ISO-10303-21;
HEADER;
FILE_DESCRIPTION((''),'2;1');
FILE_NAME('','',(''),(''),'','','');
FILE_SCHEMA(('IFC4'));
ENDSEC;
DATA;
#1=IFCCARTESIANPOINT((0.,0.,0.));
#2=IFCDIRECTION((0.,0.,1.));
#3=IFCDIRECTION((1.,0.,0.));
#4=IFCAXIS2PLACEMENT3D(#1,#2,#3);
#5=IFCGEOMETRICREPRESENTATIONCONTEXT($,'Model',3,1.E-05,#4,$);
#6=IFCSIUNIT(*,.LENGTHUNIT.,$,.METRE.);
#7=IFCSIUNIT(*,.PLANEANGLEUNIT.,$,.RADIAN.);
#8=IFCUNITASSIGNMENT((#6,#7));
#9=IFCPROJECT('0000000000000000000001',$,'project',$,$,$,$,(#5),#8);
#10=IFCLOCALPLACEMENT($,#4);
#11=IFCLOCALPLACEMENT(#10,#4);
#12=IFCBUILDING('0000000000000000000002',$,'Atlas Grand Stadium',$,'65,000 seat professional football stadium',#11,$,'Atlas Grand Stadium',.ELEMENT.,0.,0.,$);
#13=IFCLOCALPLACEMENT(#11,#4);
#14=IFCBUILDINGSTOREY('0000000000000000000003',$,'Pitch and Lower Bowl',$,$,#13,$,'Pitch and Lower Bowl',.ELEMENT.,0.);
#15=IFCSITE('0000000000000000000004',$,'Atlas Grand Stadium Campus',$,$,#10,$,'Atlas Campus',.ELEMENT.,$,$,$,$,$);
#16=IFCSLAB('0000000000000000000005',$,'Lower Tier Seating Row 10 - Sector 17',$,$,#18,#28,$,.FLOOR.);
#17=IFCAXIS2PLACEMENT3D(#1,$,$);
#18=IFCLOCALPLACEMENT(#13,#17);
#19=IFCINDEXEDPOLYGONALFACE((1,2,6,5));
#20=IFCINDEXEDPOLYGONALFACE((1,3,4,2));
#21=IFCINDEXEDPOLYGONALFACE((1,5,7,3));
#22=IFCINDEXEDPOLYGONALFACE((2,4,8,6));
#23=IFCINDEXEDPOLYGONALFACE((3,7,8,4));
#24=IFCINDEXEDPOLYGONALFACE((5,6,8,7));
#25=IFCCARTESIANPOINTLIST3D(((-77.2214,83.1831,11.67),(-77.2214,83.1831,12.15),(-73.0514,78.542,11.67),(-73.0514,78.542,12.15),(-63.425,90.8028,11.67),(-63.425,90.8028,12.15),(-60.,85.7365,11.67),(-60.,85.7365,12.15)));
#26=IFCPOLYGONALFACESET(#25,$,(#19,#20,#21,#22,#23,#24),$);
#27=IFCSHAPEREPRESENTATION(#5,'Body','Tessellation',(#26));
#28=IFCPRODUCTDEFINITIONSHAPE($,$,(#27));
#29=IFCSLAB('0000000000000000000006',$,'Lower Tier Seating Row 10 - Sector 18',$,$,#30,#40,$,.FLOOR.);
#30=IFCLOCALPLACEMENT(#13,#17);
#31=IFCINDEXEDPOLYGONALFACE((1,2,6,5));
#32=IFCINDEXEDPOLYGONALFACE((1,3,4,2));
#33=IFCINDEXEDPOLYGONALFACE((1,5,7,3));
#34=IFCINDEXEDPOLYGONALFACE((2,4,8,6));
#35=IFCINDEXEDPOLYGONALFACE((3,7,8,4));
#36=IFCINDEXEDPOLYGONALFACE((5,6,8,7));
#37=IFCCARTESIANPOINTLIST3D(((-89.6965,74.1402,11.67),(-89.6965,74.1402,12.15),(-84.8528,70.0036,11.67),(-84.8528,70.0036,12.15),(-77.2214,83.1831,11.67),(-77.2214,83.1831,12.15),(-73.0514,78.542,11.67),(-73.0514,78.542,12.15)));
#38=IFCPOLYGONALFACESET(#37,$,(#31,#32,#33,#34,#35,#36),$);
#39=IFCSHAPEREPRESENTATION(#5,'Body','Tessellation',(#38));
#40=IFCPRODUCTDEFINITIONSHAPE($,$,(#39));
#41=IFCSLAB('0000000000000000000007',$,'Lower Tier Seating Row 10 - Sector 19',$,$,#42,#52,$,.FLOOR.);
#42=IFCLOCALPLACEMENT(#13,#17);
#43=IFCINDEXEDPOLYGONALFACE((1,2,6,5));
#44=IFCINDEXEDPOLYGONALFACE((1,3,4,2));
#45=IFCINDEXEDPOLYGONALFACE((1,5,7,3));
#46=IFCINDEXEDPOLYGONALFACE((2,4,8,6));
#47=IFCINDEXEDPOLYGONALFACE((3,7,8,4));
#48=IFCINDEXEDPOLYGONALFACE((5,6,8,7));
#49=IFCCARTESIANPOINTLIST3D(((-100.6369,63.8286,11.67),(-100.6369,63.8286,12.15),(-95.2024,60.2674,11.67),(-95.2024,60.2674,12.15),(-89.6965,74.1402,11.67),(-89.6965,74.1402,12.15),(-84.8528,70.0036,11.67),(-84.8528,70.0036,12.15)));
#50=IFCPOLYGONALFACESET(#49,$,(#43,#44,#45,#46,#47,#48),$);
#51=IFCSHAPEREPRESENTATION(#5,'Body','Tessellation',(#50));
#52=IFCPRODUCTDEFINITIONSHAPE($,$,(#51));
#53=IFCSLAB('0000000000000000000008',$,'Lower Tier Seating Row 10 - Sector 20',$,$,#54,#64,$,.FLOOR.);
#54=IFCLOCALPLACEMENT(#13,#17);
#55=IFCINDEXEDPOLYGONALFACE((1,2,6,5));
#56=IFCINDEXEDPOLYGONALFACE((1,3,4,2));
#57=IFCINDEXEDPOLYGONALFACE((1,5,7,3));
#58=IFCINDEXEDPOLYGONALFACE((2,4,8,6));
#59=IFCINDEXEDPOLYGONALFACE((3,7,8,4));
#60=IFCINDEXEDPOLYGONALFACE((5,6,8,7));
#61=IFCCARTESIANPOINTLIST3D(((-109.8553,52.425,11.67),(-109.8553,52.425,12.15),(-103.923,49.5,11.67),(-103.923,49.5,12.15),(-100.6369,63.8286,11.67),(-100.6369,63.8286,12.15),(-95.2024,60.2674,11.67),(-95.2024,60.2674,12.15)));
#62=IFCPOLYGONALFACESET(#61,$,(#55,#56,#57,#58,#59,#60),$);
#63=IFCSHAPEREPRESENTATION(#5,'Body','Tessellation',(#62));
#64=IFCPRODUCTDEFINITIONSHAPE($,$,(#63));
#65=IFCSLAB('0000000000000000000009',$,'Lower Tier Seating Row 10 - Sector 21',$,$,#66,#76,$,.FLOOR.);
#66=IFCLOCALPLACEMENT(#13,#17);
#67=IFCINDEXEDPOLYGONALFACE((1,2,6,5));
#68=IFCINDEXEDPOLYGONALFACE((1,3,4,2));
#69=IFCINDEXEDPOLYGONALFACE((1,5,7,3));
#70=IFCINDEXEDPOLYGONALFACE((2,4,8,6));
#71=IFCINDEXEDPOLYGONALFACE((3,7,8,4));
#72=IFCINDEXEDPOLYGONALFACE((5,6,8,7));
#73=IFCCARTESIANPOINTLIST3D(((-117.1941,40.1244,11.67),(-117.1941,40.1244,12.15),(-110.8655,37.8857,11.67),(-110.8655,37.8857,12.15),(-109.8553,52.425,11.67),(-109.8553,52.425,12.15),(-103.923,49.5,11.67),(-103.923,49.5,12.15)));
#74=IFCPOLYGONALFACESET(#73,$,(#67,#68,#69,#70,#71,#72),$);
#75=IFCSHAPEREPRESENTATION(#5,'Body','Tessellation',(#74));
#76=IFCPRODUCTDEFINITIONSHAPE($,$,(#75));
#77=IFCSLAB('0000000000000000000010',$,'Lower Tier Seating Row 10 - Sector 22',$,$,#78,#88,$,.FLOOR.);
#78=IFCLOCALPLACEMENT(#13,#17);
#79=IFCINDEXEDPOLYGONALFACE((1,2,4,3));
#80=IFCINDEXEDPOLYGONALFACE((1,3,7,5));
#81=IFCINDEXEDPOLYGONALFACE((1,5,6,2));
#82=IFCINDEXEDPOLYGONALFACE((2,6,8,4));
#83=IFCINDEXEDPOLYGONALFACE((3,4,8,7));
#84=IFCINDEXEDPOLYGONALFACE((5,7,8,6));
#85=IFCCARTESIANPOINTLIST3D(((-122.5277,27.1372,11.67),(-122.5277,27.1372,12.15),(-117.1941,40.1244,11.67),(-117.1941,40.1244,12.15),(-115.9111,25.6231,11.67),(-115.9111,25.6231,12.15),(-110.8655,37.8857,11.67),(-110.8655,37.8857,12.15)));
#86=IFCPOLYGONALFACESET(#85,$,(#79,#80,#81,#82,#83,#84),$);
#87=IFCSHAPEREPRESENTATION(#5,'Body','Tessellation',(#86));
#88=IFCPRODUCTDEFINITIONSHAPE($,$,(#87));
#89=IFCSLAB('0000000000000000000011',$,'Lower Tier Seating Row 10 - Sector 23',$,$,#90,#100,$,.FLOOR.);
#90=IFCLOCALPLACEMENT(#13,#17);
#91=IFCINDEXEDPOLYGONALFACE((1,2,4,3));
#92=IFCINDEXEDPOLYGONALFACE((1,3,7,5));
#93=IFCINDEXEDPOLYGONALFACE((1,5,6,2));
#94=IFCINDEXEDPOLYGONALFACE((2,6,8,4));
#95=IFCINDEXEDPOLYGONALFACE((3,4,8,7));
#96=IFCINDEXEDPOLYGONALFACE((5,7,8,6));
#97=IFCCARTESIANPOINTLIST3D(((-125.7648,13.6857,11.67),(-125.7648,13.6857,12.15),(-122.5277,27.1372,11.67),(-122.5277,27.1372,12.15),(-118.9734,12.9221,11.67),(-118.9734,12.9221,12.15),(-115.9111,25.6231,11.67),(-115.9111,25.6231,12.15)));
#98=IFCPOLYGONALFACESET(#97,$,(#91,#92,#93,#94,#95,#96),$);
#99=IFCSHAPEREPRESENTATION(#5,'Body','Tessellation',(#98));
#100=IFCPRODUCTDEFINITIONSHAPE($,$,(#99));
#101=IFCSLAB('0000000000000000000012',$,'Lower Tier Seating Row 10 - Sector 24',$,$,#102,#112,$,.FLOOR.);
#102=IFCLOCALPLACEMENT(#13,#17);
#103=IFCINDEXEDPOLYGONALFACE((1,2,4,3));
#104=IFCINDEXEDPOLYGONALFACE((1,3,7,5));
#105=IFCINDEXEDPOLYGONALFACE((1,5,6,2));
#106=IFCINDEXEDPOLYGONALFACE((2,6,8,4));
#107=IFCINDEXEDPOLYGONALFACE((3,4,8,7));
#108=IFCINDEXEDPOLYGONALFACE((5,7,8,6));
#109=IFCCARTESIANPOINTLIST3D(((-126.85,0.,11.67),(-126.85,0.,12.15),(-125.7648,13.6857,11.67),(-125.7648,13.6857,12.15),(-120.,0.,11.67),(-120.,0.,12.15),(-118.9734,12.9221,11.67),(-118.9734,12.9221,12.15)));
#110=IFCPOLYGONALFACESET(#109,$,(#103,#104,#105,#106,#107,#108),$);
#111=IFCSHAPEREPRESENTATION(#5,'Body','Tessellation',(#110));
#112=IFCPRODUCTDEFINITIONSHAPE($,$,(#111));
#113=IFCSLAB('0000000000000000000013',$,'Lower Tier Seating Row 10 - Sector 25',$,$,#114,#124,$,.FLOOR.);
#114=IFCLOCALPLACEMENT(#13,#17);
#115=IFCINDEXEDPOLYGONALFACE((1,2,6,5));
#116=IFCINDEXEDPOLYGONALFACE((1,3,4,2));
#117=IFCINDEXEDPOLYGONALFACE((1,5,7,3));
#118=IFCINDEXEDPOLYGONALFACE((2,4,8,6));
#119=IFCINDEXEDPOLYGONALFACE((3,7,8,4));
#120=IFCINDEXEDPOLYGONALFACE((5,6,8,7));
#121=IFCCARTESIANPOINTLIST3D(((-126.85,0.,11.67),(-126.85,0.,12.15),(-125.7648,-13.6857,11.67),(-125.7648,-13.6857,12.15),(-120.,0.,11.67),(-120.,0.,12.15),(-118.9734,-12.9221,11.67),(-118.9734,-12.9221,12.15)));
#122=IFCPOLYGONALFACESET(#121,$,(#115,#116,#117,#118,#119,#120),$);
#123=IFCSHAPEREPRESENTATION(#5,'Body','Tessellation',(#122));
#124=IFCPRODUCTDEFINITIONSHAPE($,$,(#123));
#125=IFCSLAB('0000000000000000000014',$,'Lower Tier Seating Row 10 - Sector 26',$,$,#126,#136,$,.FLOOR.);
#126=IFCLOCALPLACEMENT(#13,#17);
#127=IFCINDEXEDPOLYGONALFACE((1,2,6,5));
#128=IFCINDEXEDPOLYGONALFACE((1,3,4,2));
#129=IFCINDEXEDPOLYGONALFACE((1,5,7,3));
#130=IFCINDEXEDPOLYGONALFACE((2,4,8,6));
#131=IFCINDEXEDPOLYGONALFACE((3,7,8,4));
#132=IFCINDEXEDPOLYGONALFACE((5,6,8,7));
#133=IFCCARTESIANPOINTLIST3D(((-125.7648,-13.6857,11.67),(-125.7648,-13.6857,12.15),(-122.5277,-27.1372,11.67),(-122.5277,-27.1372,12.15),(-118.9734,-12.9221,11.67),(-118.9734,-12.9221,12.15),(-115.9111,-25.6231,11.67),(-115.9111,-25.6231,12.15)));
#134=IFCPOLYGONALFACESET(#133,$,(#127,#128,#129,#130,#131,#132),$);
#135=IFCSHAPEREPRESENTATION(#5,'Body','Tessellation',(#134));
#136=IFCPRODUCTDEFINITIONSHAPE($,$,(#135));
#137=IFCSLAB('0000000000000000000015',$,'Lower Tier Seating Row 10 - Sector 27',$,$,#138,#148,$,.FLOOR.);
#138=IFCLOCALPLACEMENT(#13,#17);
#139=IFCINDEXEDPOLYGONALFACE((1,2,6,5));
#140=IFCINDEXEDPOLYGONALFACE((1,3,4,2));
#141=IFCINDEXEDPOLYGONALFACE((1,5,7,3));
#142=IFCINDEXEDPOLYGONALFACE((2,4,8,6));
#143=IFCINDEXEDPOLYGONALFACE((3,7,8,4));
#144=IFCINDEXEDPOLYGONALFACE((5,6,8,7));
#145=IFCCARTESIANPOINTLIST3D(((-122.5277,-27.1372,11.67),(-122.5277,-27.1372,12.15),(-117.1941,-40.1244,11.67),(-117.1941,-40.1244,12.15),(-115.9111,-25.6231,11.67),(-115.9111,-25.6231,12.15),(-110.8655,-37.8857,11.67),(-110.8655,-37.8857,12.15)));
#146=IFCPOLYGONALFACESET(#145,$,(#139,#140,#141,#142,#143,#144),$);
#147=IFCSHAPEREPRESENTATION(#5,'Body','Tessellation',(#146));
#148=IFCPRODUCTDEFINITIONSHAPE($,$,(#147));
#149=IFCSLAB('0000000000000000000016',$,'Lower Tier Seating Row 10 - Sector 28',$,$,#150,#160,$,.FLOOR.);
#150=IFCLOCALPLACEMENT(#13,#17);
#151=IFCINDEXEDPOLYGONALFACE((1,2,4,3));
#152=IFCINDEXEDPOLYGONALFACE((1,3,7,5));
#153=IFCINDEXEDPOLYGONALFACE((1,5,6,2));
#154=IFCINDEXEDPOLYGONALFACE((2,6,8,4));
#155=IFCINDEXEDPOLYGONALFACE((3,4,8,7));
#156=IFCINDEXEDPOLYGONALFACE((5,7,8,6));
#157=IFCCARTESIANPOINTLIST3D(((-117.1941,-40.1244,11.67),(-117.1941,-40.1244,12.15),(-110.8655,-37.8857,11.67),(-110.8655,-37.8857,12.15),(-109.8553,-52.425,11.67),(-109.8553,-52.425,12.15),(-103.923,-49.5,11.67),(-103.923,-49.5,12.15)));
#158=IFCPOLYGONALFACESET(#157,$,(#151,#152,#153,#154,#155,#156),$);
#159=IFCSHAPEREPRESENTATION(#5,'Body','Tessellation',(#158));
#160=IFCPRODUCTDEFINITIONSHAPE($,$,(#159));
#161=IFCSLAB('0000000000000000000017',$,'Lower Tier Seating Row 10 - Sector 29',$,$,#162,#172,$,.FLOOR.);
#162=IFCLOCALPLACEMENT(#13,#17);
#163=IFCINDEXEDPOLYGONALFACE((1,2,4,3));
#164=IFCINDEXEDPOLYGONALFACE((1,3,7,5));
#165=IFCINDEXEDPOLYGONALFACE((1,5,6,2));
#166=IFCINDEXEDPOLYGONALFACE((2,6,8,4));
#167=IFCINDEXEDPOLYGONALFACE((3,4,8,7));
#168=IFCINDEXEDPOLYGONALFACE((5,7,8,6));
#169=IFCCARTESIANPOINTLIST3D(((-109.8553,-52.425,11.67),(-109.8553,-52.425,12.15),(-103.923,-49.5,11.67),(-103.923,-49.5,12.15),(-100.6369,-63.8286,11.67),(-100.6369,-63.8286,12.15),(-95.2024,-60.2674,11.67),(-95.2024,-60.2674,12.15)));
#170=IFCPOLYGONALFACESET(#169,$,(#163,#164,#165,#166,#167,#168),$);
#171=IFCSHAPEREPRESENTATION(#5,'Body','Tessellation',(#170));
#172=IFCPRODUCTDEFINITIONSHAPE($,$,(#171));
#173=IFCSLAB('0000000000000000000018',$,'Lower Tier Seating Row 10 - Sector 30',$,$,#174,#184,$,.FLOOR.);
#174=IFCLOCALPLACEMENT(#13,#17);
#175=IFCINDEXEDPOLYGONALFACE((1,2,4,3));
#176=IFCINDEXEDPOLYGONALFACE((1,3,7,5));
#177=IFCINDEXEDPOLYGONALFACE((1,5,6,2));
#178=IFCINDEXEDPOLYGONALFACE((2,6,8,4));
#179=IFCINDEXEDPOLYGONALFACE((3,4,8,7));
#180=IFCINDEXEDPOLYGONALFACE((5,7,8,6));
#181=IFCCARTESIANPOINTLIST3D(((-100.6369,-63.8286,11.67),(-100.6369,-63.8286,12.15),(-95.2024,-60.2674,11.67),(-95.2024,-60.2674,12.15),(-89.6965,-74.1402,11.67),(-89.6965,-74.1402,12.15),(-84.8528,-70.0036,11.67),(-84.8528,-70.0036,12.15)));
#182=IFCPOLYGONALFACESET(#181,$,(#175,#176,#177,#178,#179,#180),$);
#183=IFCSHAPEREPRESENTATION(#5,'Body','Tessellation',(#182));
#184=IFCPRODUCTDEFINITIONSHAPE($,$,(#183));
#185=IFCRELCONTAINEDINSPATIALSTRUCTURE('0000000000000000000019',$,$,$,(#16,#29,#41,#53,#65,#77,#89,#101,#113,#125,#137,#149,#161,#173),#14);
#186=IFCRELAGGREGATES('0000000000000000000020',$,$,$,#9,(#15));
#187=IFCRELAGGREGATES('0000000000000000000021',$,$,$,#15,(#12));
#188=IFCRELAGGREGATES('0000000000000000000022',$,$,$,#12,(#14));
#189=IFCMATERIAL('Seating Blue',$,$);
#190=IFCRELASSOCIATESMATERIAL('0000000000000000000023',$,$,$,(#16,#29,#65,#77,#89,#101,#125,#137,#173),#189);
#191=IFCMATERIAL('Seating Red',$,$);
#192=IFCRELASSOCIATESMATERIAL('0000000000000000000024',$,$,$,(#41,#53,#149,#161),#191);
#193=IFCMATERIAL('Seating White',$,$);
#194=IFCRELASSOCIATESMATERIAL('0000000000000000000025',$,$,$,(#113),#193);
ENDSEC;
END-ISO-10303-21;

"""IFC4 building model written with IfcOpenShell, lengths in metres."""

from ifc_helpers import new_model, si_unit, frame, origin_with_axes, place, context, project, spatial, polyline, outline, extrude, material, element, save


model = new_model("IFC4")

# Units and contexts
model_context = context("Model", 3, precision=1e-05, world=origin_with_axes())
ifc_project = project(units=[si_unit("LENGTHUNIT", "METRE"), si_unit("PLANEANGLEUNIT", "RADIAN")], contexts=[model_context])

# Site, building, storey
site_placement = place(None, origin_with_axes())
site = spatial("IfcSite", under=ifc_project, at=site_placement, Name="Atlas Grand Stadium Campus", LongName="Atlas Campus", CompositionType="ELEMENT")
building_placement = place(site_placement, origin_with_axes())
building = spatial("IfcBuilding", under=site, at=building_placement, Name="Atlas Grand Stadium", ObjectType="65,000 seat professional football stadium", LongName="Atlas Grand Stadium", CompositionType="ELEMENT", ElevationOfRefHeight=0.0, ElevationOfTerrain=0.0)
storey_placement = place(building_placement, origin_with_axes())
storey = spatial("IfcBuildingStorey", under=building, at=storey_placement, Name="Pitch and Lower Bowl", LongName="Pitch and Lower Bowl", CompositionType="ELEMENT", Elevation=0.0)

# Slabs
ifc_material_1 = material(Name="Seating Blue")
slab_1_placement = place(storey_placement, frame((0.0, 0.0, 11.67), z_axis=(0.0, 0.0, 1.0), x_axis=(1.0, 0.0, 0.0)))
element("IfcSlab", 1, at=slab_1_placement, inside=storey, material=ifc_material_1, Name="Lower Tier Seating Row 10 - Sector 17", PredefinedType="FLOOR", context=model_context, shape_type="SweptSolid", body=[
    extrude(outline(polyline([(-63.425, 90.8028), (-77.2214, 83.1831), (-73.0514, 78.542), (-60.0, 85.7365), (-63.425, 90.8028)])), origin_with_axes(), (0.0, 0.0, 1.0), 0.48),
])
slab_2_placement = place(storey_placement, frame((0.0, 0.0, 11.67), z_axis=(0.0, 0.0, 1.0), x_axis=(1.0, 0.0, 0.0)))
element("IfcSlab", 2, at=slab_2_placement, inside=storey, material=ifc_material_1, Name="Lower Tier Seating Row 10 - Sector 18", PredefinedType="FLOOR", context=model_context, shape_type="SweptSolid", body=[
    extrude(outline(polyline([(-77.2214, 83.1831), (-89.6965, 74.1402), (-84.8528, 70.0036), (-73.0514, 78.542), (-77.2214, 83.1831)])), origin_with_axes(), (0.0, 0.0, 1.0), 0.48),
])
ifc_material_2 = material(Name="Seating Red")
slab_3_placement = place(storey_placement, frame((0.0, 0.0, 11.67), z_axis=(0.0, 0.0, 1.0), x_axis=(1.0, 0.0, 0.0)))
element("IfcSlab", 3, at=slab_3_placement, inside=storey, material=ifc_material_2, Name="Lower Tier Seating Row 10 - Sector 19", PredefinedType="FLOOR", context=model_context, shape_type="SweptSolid", body=[
    extrude(outline(polyline([(-89.6965, 74.1402), (-100.6369, 63.8286), (-95.2024, 60.2674), (-84.8528, 70.0036), (-89.6965, 74.1402)])), origin_with_axes(), (0.0, 0.0, 1.0), 0.48),
])
slab_4_placement = place(storey_placement, frame((0.0, 0.0, 11.67), z_axis=(0.0, 0.0, 1.0), x_axis=(1.0, 0.0, 0.0)))
element("IfcSlab", 4, at=slab_4_placement, inside=storey, material=ifc_material_2, Name="Lower Tier Seating Row 10 - Sector 20", PredefinedType="FLOOR", context=model_context, shape_type="SweptSolid", body=[
    extrude(outline(polyline([(-100.6369, 63.8286), (-109.8553, 52.425), (-103.9231, 49.5), (-95.2024, 60.2674), (-100.6369, 63.8286)])), origin_with_axes(), (0.0, 0.0, 1.0), 0.48),
])
slab_5_placement = place(storey_placement, frame((0.0, 0.0, 11.67), z_axis=(0.0, 0.0, 1.0), x_axis=(1.0, 0.0, 0.0)))
element("IfcSlab", 5, at=slab_5_placement, inside=storey, material=ifc_material_1, Name="Lower Tier Seating Row 10 - Sector 21", PredefinedType="FLOOR", context=model_context, shape_type="SweptSolid", body=[
    extrude(outline(polyline([(-109.8553, 52.425), (-117.1941, 40.1244), (-110.8655, 37.8857), (-103.9231, 49.5), (-109.8553, 52.425)])), origin_with_axes(), (0.0, 0.0, 1.0), 0.48),
])
slab_6_placement = place(storey_placement, frame((0.0, 0.0, 11.67), z_axis=(0.0, 0.0, 1.0), x_axis=(1.0, 0.0, 0.0)))
element("IfcSlab", 6, at=slab_6_placement, inside=storey, material=ifc_material_1, Name="Lower Tier Seating Row 10 - Sector 22", PredefinedType="FLOOR", context=model_context, shape_type="SweptSolid", body=[
    extrude(outline(polyline([(-117.1941, 40.1244), (-122.5277, 27.1372), (-115.9111, 25.6231), (-110.8655, 37.8857), (-117.1941, 40.1244)])), origin_with_axes(), (0.0, 0.0, 1.0), 0.48),
])
slab_7_placement = place(storey_placement, frame((0.0, 0.0, 11.67), z_axis=(0.0, 0.0, 1.0), x_axis=(1.0, 0.0, 0.0)))
element("IfcSlab", 7, at=slab_7_placement, inside=storey, material=ifc_material_1, Name="Lower Tier Seating Row 10 - Sector 23", PredefinedType="FLOOR", context=model_context, shape_type="SweptSolid", body=[
    extrude(outline(polyline([(-122.5277, 27.1372), (-125.7648, 13.6857), (-118.9734, 12.9221), (-115.9111, 25.6231), (-122.5277, 27.1372)])), origin_with_axes(), (0.0, 0.0, 1.0), 0.48),
])
slab_8_placement = place(storey_placement, frame((0.0, 0.0, 11.67), z_axis=(0.0, 0.0, 1.0), x_axis=(1.0, 0.0, 0.0)))
element("IfcSlab", 8, at=slab_8_placement, inside=storey, material=ifc_material_1, Name="Lower Tier Seating Row 10 - Sector 24", PredefinedType="FLOOR", context=model_context, shape_type="SweptSolid", body=[
    extrude(outline(polyline([(-125.7648, 13.6857), (-126.85, 0.0), (-120.0, 0.0), (-118.9734, 12.9221), (-125.7648, 13.6857)])), origin_with_axes(), (0.0, 0.0, 1.0), 0.48),
])
ifc_material_3 = material(Name="Seating White")
slab_9_placement = place(storey_placement, frame((0.0, 0.0, 11.67), z_axis=(0.0, 0.0, 1.0), x_axis=(1.0, 0.0, 0.0)))
element("IfcSlab", 9, at=slab_9_placement, inside=storey, material=ifc_material_3, Name="Lower Tier Seating Row 10 - Sector 25", PredefinedType="FLOOR", context=model_context, shape_type="SweptSolid", body=[
    extrude(outline(polyline([(-126.85, 0.0), (-125.7648, -13.6857), (-118.9734, -12.9221), (-120.0, 0.0), (-126.85, 0.0)])), origin_with_axes(), (0.0, 0.0, 1.0), 0.48),
])
slab_10_placement = place(storey_placement, frame((0.0, 0.0, 11.67), z_axis=(0.0, 0.0, 1.0), x_axis=(1.0, 0.0, 0.0)))
element("IfcSlab", 10, at=slab_10_placement, inside=storey, material=ifc_material_1, Name="Lower Tier Seating Row 10 - Sector 26", PredefinedType="FLOOR", context=model_context, shape_type="SweptSolid", body=[
    extrude(outline(polyline([(-125.7648, -13.6857), (-122.5277, -27.1372), (-115.9111, -25.6231), (-118.9734, -12.9221), (-125.7648, -13.6857)])), origin_with_axes(), (0.0, 0.0, 1.0), 0.48),
])
slab_11_placement = place(storey_placement, frame((0.0, 0.0, 11.67), z_axis=(0.0, 0.0, 1.0), x_axis=(1.0, 0.0, 0.0)))
element("IfcSlab", 11, at=slab_11_placement, inside=storey, material=ifc_material_1, Name="Lower Tier Seating Row 10 - Sector 27", PredefinedType="FLOOR", context=model_context, shape_type="SweptSolid", body=[
    extrude(outline(polyline([(-122.5277, -27.1372), (-117.1941, -40.1244), (-110.8655, -37.8857), (-115.9111, -25.6231), (-122.5277, -27.1372)])), origin_with_axes(), (0.0, 0.0, 1.0), 0.48),
])
slab_12_placement = place(storey_placement, frame((0.0, 0.0, 11.67), z_axis=(0.0, 0.0, 1.0), x_axis=(1.0, 0.0, 0.0)))
element("IfcSlab", 12, at=slab_12_placement, inside=storey, material=ifc_material_2, Name="Lower Tier Seating Row 10 - Sector 28", PredefinedType="FLOOR", context=model_context, shape_type="SweptSolid", body=[
    extrude(outline(polyline([(-117.1941, -40.1244), (-109.8553, -52.425), (-103.9231, -49.5), (-110.8655, -37.8857), (-117.1941, -40.1244)])), origin_with_axes(), (0.0, 0.0, 1.0), 0.48),
])
slab_13_placement = place(storey_placement, frame((0.0, 0.0, 11.67), z_axis=(0.0, 0.0, 1.0), x_axis=(1.0, 0.0, 0.0)))
element("IfcSlab", 13, at=slab_13_placement, inside=storey, material=ifc_material_2, Name="Lower Tier Seating Row 10 - Sector 29", PredefinedType="FLOOR", context=model_context, shape_type="SweptSolid", body=[
    extrude(outline(polyline([(-109.8553, -52.425), (-100.6369, -63.8286), (-95.2024, -60.2674), (-103.9231, -49.5), (-109.8553, -52.425)])), origin_with_axes(), (0.0, 0.0, 1.0), 0.48),
])
slab_14_placement = place(storey_placement, frame((0.0, 0.0, 11.67), z_axis=(0.0, 0.0, 1.0), x_axis=(1.0, 0.0, 0.0)))
element("IfcSlab", 14, at=slab_14_placement, inside=storey, material=ifc_material_1, Name="Lower Tier Seating Row 10 - Sector 30", PredefinedType="FLOOR", context=model_context, shape_type="SweptSolid", body=[
    extrude(outline(polyline([(-100.6369, -63.8286), (-89.6965, -74.1402), (-84.8528, -70.0036), (-95.2024, -60.2674), (-100.6369, -63.8286)])), origin_with_axes(), (0.0, 0.0, 1.0), 0.48),
])

save(model, "model.ifc")
